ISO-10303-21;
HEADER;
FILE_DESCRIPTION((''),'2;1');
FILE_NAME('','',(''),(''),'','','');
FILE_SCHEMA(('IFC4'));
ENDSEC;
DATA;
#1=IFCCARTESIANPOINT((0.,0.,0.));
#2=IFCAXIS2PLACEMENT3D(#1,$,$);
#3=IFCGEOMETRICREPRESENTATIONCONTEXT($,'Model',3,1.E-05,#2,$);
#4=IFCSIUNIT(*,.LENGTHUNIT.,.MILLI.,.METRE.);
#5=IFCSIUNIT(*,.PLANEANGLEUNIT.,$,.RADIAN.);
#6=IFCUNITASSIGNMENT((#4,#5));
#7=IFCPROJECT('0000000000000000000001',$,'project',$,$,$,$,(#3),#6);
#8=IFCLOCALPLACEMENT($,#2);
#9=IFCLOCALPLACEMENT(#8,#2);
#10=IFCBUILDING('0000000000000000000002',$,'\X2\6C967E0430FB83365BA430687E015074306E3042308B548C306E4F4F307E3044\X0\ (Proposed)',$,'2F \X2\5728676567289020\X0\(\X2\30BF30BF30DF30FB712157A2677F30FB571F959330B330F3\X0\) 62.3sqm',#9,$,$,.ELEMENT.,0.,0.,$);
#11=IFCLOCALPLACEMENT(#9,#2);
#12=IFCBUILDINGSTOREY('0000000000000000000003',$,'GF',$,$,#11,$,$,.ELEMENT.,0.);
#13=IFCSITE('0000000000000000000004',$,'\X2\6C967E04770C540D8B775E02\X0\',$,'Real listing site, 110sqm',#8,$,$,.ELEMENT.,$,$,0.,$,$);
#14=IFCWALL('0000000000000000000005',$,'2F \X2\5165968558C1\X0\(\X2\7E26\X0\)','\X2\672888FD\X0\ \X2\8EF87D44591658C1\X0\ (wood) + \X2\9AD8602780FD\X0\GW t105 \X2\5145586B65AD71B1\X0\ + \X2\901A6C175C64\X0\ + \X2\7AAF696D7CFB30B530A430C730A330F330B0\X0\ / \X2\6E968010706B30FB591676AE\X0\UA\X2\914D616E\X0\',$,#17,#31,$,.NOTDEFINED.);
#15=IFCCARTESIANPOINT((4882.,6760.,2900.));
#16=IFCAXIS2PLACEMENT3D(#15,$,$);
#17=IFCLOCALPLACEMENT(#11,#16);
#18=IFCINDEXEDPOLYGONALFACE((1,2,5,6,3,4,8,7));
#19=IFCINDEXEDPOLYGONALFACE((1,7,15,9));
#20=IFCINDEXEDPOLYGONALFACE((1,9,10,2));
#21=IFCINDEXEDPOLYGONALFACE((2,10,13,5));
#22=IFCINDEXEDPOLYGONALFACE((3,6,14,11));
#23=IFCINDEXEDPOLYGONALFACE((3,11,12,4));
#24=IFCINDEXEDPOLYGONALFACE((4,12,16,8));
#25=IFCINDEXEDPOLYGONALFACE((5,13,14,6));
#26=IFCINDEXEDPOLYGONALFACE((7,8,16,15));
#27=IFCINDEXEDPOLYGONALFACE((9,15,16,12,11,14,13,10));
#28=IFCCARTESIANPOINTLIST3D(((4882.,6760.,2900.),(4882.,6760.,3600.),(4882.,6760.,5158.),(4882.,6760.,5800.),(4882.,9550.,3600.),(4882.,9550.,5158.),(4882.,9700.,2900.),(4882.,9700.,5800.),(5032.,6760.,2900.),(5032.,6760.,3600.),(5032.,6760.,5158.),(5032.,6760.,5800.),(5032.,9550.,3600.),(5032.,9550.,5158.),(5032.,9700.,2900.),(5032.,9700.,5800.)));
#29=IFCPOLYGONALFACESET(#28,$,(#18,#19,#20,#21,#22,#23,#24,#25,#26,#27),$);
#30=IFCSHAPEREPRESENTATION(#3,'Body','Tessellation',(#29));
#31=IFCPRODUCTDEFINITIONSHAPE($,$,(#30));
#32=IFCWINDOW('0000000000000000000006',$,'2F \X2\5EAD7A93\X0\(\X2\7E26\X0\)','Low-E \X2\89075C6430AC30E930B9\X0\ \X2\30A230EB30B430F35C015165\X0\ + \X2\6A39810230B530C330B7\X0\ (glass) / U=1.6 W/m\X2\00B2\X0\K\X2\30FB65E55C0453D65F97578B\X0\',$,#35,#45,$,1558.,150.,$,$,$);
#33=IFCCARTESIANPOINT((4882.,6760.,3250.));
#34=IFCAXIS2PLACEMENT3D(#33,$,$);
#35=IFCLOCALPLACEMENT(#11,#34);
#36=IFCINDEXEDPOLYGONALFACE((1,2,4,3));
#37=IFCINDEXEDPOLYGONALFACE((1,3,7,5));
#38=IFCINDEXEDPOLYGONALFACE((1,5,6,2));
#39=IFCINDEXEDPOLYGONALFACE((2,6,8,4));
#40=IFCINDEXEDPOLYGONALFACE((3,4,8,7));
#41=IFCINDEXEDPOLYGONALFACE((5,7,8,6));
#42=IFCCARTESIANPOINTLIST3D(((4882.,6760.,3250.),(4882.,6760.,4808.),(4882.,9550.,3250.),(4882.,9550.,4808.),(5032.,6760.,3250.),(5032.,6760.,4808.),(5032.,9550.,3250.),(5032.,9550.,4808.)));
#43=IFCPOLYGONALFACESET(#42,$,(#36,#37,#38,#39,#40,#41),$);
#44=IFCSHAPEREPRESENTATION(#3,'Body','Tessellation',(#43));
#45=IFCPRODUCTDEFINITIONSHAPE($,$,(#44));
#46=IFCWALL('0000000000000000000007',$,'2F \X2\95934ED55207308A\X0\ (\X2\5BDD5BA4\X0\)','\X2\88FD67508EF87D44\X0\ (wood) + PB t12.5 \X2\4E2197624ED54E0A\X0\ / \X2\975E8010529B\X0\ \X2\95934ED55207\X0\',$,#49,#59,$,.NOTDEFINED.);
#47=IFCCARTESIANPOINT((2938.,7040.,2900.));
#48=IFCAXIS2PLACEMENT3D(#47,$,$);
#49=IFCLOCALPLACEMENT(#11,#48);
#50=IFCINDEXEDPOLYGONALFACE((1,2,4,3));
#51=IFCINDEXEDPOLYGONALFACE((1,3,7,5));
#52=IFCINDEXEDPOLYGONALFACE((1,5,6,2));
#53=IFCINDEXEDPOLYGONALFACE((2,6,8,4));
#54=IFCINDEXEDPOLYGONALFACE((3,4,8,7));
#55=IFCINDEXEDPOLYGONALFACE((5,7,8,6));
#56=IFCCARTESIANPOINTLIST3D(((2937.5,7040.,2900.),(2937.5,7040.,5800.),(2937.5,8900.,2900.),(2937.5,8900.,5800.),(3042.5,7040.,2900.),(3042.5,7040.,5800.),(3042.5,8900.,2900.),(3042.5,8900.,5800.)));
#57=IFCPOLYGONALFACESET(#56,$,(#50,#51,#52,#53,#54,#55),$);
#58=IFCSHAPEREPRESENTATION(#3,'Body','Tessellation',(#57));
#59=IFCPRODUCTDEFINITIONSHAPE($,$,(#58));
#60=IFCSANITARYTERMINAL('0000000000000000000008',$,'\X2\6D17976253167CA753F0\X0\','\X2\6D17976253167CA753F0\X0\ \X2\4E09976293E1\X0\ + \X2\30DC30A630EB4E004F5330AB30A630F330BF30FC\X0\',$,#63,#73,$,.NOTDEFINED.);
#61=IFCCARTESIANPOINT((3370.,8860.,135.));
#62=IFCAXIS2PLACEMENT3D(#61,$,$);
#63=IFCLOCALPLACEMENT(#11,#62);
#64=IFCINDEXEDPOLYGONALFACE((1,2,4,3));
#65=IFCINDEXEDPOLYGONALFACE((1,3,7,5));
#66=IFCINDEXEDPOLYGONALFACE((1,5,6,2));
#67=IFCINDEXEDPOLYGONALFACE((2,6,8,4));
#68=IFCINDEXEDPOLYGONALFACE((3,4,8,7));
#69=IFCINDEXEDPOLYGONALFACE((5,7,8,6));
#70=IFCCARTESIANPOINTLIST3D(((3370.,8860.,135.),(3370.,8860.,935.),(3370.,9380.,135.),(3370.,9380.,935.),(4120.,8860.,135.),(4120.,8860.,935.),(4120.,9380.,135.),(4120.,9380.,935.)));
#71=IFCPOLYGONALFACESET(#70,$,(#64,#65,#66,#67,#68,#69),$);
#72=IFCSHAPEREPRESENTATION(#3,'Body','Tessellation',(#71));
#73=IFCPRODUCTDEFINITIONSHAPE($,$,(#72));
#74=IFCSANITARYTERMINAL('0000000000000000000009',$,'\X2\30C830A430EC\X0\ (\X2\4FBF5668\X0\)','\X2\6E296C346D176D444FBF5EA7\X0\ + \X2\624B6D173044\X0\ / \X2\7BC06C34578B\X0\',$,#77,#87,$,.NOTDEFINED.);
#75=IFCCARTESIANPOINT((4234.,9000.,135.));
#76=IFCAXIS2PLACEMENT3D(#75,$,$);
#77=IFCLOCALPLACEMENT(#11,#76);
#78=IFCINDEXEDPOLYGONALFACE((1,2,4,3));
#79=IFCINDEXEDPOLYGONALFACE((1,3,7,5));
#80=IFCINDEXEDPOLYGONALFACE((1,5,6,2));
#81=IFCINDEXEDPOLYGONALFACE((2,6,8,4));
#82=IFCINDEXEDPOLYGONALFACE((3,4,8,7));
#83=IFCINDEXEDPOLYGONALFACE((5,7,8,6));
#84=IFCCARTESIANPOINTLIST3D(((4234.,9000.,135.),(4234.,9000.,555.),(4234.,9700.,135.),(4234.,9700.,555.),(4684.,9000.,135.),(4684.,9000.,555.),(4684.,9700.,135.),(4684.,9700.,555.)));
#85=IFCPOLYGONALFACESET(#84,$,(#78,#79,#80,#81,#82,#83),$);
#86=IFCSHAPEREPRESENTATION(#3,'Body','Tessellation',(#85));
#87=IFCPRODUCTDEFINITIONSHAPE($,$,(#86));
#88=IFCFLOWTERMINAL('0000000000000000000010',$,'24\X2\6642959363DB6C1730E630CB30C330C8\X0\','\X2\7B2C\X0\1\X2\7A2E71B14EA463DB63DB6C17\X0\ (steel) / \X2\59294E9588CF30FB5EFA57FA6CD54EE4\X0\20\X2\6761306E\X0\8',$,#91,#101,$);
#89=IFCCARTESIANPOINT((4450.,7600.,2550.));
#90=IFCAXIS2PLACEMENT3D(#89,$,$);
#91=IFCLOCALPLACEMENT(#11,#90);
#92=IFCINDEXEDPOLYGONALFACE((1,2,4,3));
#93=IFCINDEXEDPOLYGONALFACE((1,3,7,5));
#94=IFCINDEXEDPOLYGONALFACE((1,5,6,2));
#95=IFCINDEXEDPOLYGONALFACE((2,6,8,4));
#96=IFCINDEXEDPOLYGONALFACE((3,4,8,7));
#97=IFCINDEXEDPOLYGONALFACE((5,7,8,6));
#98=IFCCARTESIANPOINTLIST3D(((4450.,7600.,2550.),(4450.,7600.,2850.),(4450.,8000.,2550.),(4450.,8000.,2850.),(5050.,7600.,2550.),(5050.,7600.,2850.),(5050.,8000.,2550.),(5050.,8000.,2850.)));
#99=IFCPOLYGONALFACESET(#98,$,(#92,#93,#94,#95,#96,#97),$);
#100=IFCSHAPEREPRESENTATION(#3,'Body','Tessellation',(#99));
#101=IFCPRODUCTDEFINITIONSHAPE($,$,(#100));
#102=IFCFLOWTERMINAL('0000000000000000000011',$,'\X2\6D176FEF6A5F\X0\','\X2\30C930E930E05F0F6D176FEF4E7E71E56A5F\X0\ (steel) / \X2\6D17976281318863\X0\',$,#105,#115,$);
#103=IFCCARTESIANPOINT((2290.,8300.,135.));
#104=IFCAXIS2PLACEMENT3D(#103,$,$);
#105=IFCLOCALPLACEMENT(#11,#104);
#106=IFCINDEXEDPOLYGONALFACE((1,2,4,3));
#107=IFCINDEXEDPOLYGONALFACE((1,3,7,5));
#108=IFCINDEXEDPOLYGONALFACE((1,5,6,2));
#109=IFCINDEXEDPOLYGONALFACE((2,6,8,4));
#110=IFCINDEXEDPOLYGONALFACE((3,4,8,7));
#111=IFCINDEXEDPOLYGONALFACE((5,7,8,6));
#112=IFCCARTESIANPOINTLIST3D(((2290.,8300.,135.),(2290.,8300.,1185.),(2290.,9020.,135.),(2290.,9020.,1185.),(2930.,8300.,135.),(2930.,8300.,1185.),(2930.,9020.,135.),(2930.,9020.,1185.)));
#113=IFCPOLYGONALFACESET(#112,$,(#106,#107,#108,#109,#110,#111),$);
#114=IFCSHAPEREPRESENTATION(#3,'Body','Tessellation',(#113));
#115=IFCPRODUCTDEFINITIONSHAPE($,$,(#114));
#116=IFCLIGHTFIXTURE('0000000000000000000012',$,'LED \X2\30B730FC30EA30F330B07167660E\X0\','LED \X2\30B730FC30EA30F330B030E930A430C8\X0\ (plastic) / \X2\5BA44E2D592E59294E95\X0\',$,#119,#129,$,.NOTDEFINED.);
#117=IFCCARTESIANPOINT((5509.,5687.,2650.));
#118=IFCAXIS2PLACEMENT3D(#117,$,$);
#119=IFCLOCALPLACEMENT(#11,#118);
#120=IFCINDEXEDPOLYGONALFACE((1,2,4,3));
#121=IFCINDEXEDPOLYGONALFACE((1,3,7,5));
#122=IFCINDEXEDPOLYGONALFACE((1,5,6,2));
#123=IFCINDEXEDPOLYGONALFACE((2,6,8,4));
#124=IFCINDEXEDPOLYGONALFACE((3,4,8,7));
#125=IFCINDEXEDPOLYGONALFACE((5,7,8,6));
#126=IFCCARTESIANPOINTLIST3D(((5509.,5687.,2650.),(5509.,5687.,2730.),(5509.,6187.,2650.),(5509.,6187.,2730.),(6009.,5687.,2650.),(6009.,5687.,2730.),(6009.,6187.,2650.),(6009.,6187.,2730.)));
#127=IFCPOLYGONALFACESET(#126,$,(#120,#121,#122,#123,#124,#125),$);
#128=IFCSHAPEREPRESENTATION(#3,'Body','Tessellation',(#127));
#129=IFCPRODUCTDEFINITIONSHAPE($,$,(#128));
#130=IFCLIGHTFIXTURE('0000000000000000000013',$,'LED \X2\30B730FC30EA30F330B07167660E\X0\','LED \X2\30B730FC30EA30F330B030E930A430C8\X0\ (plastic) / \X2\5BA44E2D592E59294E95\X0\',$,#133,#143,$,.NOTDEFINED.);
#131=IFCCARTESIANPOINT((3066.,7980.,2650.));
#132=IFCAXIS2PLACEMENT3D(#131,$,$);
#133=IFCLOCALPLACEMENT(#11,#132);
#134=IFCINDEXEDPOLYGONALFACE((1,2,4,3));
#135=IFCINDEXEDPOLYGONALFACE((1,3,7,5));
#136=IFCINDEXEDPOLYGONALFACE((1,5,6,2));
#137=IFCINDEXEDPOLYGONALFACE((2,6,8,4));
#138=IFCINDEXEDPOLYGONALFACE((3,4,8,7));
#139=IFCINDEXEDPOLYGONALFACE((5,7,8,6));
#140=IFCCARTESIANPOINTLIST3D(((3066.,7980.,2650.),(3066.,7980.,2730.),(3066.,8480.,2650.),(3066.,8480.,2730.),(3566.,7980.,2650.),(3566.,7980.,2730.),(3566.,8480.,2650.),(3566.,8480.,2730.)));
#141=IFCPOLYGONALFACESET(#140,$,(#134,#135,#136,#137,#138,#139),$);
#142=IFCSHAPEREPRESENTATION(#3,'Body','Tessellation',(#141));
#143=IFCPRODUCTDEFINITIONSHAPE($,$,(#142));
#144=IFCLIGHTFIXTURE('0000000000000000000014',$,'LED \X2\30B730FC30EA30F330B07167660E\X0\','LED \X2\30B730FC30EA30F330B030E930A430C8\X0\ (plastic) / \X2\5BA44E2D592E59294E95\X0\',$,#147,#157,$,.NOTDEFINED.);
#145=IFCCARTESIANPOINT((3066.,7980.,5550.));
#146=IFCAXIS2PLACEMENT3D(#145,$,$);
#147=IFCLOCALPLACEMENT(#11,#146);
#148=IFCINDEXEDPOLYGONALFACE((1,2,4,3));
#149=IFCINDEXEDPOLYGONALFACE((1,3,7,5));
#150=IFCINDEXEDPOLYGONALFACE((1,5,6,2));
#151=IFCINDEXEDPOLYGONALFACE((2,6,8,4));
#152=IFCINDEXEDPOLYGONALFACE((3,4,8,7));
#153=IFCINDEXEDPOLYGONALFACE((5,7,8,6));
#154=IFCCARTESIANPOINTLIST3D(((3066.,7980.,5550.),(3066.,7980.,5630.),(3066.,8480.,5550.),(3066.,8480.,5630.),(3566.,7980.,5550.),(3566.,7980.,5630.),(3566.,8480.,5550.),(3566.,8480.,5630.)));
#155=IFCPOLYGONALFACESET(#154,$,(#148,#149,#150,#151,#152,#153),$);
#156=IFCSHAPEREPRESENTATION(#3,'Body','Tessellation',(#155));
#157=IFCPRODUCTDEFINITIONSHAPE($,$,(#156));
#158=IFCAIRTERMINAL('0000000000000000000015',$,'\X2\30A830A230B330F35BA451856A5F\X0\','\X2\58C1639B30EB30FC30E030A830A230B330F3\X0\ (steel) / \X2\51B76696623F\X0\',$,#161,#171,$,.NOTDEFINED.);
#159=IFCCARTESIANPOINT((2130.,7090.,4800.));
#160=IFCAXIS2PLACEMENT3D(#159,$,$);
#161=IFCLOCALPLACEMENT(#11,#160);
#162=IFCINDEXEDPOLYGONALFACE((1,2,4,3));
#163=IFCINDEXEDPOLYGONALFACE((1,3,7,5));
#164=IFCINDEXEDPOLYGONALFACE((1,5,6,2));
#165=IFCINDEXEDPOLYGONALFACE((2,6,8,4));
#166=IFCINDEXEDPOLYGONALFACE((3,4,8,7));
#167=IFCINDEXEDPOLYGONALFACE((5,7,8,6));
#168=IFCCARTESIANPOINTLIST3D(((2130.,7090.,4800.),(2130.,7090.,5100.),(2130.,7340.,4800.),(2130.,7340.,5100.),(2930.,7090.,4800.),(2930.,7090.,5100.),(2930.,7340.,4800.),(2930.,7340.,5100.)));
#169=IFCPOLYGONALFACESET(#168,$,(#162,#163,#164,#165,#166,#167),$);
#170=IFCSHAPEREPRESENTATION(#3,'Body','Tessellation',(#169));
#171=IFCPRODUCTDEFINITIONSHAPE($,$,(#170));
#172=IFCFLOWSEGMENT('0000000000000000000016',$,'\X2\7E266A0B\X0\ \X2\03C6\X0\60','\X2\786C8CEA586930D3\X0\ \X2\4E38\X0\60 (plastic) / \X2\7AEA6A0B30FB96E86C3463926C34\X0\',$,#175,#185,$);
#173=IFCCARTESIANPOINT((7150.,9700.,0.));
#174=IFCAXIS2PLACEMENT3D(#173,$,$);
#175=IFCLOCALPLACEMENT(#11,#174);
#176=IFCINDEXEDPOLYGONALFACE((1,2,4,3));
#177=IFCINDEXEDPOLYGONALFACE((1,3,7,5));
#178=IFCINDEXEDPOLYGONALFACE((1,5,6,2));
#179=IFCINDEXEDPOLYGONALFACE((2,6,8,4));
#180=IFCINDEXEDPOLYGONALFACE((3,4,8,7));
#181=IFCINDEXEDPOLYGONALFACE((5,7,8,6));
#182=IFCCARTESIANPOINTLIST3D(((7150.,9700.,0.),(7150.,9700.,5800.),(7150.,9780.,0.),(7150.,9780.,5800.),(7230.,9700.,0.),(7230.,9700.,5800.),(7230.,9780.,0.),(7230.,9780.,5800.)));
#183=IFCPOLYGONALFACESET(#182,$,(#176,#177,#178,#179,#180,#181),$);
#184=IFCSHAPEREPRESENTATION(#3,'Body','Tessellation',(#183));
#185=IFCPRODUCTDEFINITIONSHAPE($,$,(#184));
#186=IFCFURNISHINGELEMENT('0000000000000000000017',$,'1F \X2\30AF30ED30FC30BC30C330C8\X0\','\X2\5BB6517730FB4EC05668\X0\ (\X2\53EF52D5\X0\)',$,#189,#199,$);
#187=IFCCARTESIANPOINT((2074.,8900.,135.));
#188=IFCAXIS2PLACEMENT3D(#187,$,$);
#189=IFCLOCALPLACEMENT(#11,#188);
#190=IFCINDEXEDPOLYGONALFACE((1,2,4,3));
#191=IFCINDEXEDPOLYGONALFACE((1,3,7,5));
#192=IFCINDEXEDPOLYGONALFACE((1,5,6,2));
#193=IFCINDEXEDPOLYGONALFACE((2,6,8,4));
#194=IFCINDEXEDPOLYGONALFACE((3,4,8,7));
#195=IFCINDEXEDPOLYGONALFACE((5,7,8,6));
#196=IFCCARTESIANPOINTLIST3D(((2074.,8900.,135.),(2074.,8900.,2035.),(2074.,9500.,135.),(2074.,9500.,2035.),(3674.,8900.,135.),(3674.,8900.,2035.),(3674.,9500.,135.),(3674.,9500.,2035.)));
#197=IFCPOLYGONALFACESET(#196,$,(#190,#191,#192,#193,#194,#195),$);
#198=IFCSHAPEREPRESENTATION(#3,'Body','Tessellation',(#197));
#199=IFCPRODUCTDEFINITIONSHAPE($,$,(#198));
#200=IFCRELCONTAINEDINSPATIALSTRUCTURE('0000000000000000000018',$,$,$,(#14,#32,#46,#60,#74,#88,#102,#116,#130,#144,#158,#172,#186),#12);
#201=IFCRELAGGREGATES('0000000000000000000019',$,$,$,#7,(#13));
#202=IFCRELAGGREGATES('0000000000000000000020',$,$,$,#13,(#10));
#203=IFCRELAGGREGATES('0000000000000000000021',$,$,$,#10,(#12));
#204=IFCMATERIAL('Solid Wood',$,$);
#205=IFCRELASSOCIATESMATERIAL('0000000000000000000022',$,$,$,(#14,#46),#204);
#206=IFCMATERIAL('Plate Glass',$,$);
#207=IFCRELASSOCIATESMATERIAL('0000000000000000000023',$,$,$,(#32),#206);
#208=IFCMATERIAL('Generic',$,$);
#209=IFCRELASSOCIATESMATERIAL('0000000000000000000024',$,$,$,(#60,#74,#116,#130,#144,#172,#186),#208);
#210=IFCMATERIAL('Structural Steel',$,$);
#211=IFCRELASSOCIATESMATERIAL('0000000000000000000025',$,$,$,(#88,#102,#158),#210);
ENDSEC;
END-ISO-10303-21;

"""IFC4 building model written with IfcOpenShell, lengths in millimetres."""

from ifc_helpers import new_model, si_unit, frame, frame_2d, origin, place, context, project, spatial, rectangle, extrude, material, element, fill, save


model = new_model("IFC4")

# Units and contexts
model_context = context("Model", 3, precision=1e-05, world=origin())
ifc_project = project(units=[si_unit("LENGTHUNIT", "METRE", prefix="MILLI"), si_unit("PLANEANGLEUNIT", "RADIAN")], contexts=[model_context])

# Site, building, storey
site_placement = place(None, origin())
site = spatial("IfcSite", under=ifc_project, at=site_placement, Name="沖縄県名護市", ObjectType="Real listing site, 110sqm", CompositionType="ELEMENT", RefElevation=0.0)
building_placement = place(site_placement, origin())
building = spatial("IfcBuilding", under=site, at=building_placement, Name="沖縄・茶室と縁側のある和の住まい (Proposed)", ObjectType="2F 在来木造(タタミ・無垢板・土間コン) 62.3sqm", CompositionType="ELEMENT", ElevationOfRefHeight=0.0, ElevationOfTerrain=0.0)
storey_placement = place(building_placement, origin())
storey = spatial("IfcBuildingStorey", under=building, at=storey_placement, Name="GF", CompositionType="ELEMENT", Elevation=0.0)

# Shared definitions
ifc_material_1 = material(Name="Solid Wood")

# Shared definitions
ifc_material_2 = material(Name="Plate Glass")

# Wall, opening, window
wall_1_placement = place(storey_placement, frame((4882.0, 6760.0, 2900.0)))
wall_1 = element("IfcWall", 1, at=wall_1_placement, inside=storey, material=ifc_material_1, Name="2F 入隅壁(縦)", Description="木製 軸組外壁 (wood) + 高性能GW t105 充填断熱 + 通気層 + 窯業系サイディング / 準耐火・外皮UA配慮", PredefinedType="NOTDEFINED", context=model_context, shape_type="SweptSolid", body=[
    extrude(rectangle(XDim=150.0, YDim=2940.0, at=frame_2d((75.0, 1470.0))), frame((4882.0, 6760.0, 2900.0)), (0.0, 0.0, 1.0), 2900.0),
])
opening_1_placement = place(storey_placement, frame((4882.0, 6760.0, 3250.0)))
opening_1 = element("IfcOpeningElement", 2, at=opening_1_placement, cuts=wall_1, PredefinedType="NOTDEFINED", context=model_context, shape_type="SweptSolid", body=[
    extrude(rectangle(XDim=150.0, YDim=2790.0, at=frame_2d((75.0, 1395.0))), frame((4882.0, 6760.0, 3250.0)), (0.0, 0.0, 1.0), 1558.0),
])
window_1_placement = place(storey_placement, frame((4882.0, 6760.0, 3250.0)))
window_1 = element("IfcWindow", 3, at=window_1_placement, inside=storey, material=ifc_material_2, Name="2F 庭窓(縦)", Description="Low-E 複層ガラス アルゴン封入 + 樹脂サッシ (glass) / U=1.6 W/m²K・日射取得型", OverallHeight=1558.0, OverallWidth=150.0, context=model_context, shape_type="SweptSolid", body=[
    extrude(rectangle(XDim=150.0, YDim=2790.0, at=frame_2d((75.0, 1395.0))), frame((4882.0, 6760.0, 3250.0)), (0.0, 0.0, 1.0), 1558.0),
])
fill(opening_1, window_1)

# Wall
wall_2_placement = place(storey_placement, frame((2938.0, 7040.0, 2900.0)))
element("IfcWall", 4, at=wall_2_placement, inside=storey, material=ifc_material_1, Name="2F 間仕切り (寝室)", Description="製材軸組 (wood) + PB t12.5 両面仕上 / 非耐力 間仕切", PredefinedType="NOTDEFINED", context=model_context, shape_type="SweptSolid", body=[
    extrude(rectangle(XDim=105.0, YDim=1860.0, at=frame_2d((52.0, 930.0))), frame((2938.0, 7040.0, 2900.0)), (0.0, 0.0, 1.0), 2900.0),
])

# Sanitary terminals
ifc_material_3 = material(Name="Generic")
sanitary_terminal_1_placement = place(storey_placement, frame((3370.0, 8860.0, 135.0)))
element("IfcSanitaryTerminal", 5, at=sanitary_terminal_1_placement, inside=storey, material=ifc_material_3, Name="洗面化粧台", Description="洗面化粧台 三面鏡 + ボウル一体カウンター", PredefinedType="NOTDEFINED", context=model_context, shape_type="SweptSolid", body=[
    extrude(rectangle(XDim=750.0, YDim=520.0, at=frame_2d((375.0, 260.0))), frame((3370.0, 8860.0, 135.0)), (0.0, 0.0, 1.0), 800.0),
])
sanitary_terminal_2_placement = place(storey_placement, frame((4234.0, 9000.0, 135.0)))
element("IfcSanitaryTerminal", 6, at=sanitary_terminal_2_placement, inside=storey, material=ifc_material_3, Name="トイレ (便器)", Description="温水洗浄便座 + 手洗い / 節水型", PredefinedType="NOTDEFINED", context=model_context, shape_type="SweptSolid", body=[
    extrude(rectangle(XDim=450.0, YDim=700.0, at=frame_2d((225.0, 350.0))), frame((4234.0, 9000.0, 135.0)), (0.0, 0.0, 1.0), 420.0),
])

# Flow terminals
ifc_material_4 = material(Name="Structural Steel")
flow_terminal_1_placement = place(storey_placement, frame((4450.0, 7600.0, 2550.0)))
element("IfcFlowTerminal", 7, at=flow_terminal_1_placement, inside=storey, material=ifc_material_4, Name="24時間換気ユニット", Description="第1種熱交換換気 (steel) / 天井裏・建基法令20条の8", context=model_context, shape_type="SweptSolid", body=[
    extrude(rectangle(XDim=600.0, YDim=400.0, at=frame_2d((300.0, 200.0))), frame((4450.0, 7600.0, 2550.0)), (0.0, 0.0, 1.0), 300.0),
])
flow_terminal_2_placement = place(storey_placement, frame((2290.0, 8300.0, 135.0)))
element("IfcFlowTerminal", 8, at=flow_terminal_2_placement, inside=storey, material=ifc_material_4, Name="洗濯機", Description="ドラム式洗濯乾燥機 (steel) / 洗面脱衣", context=model_context, shape_type="SweptSolid", body=[
    extrude(rectangle(XDim=640.0, YDim=720.0, at=frame_2d((320.0, 360.0))), frame((2290.0, 8300.0, 135.0)), (0.0, 0.0, 1.0), 1050.0),
])

# Light fixtures
light_fixture_1_placement = place(storey_placement, frame((5509.0, 5687.0, 2650.0)))
element("IfcLightFixture", 9, at=light_fixture_1_placement, inside=storey, material=ifc_material_3, Name="LED シーリング照明", Description="LED シーリングライト (plastic) / 室中央天井", PredefinedType="NOTDEFINED", context=model_context, shape_type="SweptSolid", body=[
    extrude(rectangle(XDim=500.0, YDim=500.0, at=frame_2d((250.0, 250.0))), frame((5509.0, 5687.0, 2650.0)), (0.0, 0.0, 1.0), 80.0),
])
light_fixture_2_placement = place(storey_placement, frame((3066.0, 7980.0, 2650.0)))
element("IfcLightFixture", 10, at=light_fixture_2_placement, inside=storey, material=ifc_material_3, Name="LED シーリング照明", Description="LED シーリングライト (plastic) / 室中央天井", PredefinedType="NOTDEFINED", context=model_context, shape_type="SweptSolid", body=[
    extrude(rectangle(XDim=500.0, YDim=500.0, at=frame_2d((250.0, 250.0))), frame((3066.0, 7980.0, 2650.0)), (0.0, 0.0, 1.0), 80.0),
])
light_fixture_3_placement = place(storey_placement, frame((3066.0, 7980.0, 5550.0)))
element("IfcLightFixture", 11, at=light_fixture_3_placement, inside=storey, material=ifc_material_3, Name="LED シーリング照明", Description="LED シーリングライト (plastic) / 室中央天井", PredefinedType="NOTDEFINED", context=model_context, shape_type="SweptSolid", body=[
    extrude(rectangle(XDim=500.0, YDim=500.0, at=frame_2d((250.0, 250.0))), frame((3066.0, 7980.0, 5550.0)), (0.0, 0.0, 1.0), 80.0),
])

# Air terminal
air_terminal_placement = place(storey_placement, frame((2130.0, 7090.0, 4800.0)))
element("IfcAirTerminal", 12, at=air_terminal_placement, inside=storey, material=ifc_material_4, Name="エアコン室内機", Description="壁掛ルームエアコン (steel) / 冷暖房", PredefinedType="NOTDEFINED", context=model_context, shape_type="SweptSolid", body=[
    extrude(rectangle(XDim=800.0, YDim=250.0, at=frame_2d((400.0, 125.0))), frame((2130.0, 7090.0, 4800.0)), (0.0, 0.0, 1.0), 300.0),
])

# Flow segment
flow_segment_placement = place(storey_placement, frame((7150.0, 9700.0, 0.0)))
element("IfcFlowSegment", 13, at=flow_segment_placement, inside=storey, material=ifc_material_3, Name="縦樋 φ60", Description="硬質塩ビ 丸60 (plastic) / 竪樋・雨水排水", context=model_context, shape_type="SweptSolid", body=[
    extrude(rectangle(XDim=80.0, YDim=80.0, at=frame_2d((40.0, 40.0))), frame((7150.0, 9700.0, 0.0)), (0.0, 0.0, 1.0), 5800.0),
])

# Furnishing element
furnishing_1_placement = place(storey_placement, frame((2074.0, 8900.0, 135.0)))
element("IfcFurnishingElement", 14, at=furnishing_1_placement, inside=storey, material=ifc_material_3, Name="1F クローゼット", Description="家具・什器 (可動)", context=model_context, shape_type="SweptSolid", body=[
    extrude(rectangle(XDim=1600.0, YDim=600.0, at=frame_2d((800.0, 300.0))), frame((2074.0, 8900.0, 135.0)), (0.0, 0.0, 1.0), 1900.0),
])

save(model, "model.ifc")
